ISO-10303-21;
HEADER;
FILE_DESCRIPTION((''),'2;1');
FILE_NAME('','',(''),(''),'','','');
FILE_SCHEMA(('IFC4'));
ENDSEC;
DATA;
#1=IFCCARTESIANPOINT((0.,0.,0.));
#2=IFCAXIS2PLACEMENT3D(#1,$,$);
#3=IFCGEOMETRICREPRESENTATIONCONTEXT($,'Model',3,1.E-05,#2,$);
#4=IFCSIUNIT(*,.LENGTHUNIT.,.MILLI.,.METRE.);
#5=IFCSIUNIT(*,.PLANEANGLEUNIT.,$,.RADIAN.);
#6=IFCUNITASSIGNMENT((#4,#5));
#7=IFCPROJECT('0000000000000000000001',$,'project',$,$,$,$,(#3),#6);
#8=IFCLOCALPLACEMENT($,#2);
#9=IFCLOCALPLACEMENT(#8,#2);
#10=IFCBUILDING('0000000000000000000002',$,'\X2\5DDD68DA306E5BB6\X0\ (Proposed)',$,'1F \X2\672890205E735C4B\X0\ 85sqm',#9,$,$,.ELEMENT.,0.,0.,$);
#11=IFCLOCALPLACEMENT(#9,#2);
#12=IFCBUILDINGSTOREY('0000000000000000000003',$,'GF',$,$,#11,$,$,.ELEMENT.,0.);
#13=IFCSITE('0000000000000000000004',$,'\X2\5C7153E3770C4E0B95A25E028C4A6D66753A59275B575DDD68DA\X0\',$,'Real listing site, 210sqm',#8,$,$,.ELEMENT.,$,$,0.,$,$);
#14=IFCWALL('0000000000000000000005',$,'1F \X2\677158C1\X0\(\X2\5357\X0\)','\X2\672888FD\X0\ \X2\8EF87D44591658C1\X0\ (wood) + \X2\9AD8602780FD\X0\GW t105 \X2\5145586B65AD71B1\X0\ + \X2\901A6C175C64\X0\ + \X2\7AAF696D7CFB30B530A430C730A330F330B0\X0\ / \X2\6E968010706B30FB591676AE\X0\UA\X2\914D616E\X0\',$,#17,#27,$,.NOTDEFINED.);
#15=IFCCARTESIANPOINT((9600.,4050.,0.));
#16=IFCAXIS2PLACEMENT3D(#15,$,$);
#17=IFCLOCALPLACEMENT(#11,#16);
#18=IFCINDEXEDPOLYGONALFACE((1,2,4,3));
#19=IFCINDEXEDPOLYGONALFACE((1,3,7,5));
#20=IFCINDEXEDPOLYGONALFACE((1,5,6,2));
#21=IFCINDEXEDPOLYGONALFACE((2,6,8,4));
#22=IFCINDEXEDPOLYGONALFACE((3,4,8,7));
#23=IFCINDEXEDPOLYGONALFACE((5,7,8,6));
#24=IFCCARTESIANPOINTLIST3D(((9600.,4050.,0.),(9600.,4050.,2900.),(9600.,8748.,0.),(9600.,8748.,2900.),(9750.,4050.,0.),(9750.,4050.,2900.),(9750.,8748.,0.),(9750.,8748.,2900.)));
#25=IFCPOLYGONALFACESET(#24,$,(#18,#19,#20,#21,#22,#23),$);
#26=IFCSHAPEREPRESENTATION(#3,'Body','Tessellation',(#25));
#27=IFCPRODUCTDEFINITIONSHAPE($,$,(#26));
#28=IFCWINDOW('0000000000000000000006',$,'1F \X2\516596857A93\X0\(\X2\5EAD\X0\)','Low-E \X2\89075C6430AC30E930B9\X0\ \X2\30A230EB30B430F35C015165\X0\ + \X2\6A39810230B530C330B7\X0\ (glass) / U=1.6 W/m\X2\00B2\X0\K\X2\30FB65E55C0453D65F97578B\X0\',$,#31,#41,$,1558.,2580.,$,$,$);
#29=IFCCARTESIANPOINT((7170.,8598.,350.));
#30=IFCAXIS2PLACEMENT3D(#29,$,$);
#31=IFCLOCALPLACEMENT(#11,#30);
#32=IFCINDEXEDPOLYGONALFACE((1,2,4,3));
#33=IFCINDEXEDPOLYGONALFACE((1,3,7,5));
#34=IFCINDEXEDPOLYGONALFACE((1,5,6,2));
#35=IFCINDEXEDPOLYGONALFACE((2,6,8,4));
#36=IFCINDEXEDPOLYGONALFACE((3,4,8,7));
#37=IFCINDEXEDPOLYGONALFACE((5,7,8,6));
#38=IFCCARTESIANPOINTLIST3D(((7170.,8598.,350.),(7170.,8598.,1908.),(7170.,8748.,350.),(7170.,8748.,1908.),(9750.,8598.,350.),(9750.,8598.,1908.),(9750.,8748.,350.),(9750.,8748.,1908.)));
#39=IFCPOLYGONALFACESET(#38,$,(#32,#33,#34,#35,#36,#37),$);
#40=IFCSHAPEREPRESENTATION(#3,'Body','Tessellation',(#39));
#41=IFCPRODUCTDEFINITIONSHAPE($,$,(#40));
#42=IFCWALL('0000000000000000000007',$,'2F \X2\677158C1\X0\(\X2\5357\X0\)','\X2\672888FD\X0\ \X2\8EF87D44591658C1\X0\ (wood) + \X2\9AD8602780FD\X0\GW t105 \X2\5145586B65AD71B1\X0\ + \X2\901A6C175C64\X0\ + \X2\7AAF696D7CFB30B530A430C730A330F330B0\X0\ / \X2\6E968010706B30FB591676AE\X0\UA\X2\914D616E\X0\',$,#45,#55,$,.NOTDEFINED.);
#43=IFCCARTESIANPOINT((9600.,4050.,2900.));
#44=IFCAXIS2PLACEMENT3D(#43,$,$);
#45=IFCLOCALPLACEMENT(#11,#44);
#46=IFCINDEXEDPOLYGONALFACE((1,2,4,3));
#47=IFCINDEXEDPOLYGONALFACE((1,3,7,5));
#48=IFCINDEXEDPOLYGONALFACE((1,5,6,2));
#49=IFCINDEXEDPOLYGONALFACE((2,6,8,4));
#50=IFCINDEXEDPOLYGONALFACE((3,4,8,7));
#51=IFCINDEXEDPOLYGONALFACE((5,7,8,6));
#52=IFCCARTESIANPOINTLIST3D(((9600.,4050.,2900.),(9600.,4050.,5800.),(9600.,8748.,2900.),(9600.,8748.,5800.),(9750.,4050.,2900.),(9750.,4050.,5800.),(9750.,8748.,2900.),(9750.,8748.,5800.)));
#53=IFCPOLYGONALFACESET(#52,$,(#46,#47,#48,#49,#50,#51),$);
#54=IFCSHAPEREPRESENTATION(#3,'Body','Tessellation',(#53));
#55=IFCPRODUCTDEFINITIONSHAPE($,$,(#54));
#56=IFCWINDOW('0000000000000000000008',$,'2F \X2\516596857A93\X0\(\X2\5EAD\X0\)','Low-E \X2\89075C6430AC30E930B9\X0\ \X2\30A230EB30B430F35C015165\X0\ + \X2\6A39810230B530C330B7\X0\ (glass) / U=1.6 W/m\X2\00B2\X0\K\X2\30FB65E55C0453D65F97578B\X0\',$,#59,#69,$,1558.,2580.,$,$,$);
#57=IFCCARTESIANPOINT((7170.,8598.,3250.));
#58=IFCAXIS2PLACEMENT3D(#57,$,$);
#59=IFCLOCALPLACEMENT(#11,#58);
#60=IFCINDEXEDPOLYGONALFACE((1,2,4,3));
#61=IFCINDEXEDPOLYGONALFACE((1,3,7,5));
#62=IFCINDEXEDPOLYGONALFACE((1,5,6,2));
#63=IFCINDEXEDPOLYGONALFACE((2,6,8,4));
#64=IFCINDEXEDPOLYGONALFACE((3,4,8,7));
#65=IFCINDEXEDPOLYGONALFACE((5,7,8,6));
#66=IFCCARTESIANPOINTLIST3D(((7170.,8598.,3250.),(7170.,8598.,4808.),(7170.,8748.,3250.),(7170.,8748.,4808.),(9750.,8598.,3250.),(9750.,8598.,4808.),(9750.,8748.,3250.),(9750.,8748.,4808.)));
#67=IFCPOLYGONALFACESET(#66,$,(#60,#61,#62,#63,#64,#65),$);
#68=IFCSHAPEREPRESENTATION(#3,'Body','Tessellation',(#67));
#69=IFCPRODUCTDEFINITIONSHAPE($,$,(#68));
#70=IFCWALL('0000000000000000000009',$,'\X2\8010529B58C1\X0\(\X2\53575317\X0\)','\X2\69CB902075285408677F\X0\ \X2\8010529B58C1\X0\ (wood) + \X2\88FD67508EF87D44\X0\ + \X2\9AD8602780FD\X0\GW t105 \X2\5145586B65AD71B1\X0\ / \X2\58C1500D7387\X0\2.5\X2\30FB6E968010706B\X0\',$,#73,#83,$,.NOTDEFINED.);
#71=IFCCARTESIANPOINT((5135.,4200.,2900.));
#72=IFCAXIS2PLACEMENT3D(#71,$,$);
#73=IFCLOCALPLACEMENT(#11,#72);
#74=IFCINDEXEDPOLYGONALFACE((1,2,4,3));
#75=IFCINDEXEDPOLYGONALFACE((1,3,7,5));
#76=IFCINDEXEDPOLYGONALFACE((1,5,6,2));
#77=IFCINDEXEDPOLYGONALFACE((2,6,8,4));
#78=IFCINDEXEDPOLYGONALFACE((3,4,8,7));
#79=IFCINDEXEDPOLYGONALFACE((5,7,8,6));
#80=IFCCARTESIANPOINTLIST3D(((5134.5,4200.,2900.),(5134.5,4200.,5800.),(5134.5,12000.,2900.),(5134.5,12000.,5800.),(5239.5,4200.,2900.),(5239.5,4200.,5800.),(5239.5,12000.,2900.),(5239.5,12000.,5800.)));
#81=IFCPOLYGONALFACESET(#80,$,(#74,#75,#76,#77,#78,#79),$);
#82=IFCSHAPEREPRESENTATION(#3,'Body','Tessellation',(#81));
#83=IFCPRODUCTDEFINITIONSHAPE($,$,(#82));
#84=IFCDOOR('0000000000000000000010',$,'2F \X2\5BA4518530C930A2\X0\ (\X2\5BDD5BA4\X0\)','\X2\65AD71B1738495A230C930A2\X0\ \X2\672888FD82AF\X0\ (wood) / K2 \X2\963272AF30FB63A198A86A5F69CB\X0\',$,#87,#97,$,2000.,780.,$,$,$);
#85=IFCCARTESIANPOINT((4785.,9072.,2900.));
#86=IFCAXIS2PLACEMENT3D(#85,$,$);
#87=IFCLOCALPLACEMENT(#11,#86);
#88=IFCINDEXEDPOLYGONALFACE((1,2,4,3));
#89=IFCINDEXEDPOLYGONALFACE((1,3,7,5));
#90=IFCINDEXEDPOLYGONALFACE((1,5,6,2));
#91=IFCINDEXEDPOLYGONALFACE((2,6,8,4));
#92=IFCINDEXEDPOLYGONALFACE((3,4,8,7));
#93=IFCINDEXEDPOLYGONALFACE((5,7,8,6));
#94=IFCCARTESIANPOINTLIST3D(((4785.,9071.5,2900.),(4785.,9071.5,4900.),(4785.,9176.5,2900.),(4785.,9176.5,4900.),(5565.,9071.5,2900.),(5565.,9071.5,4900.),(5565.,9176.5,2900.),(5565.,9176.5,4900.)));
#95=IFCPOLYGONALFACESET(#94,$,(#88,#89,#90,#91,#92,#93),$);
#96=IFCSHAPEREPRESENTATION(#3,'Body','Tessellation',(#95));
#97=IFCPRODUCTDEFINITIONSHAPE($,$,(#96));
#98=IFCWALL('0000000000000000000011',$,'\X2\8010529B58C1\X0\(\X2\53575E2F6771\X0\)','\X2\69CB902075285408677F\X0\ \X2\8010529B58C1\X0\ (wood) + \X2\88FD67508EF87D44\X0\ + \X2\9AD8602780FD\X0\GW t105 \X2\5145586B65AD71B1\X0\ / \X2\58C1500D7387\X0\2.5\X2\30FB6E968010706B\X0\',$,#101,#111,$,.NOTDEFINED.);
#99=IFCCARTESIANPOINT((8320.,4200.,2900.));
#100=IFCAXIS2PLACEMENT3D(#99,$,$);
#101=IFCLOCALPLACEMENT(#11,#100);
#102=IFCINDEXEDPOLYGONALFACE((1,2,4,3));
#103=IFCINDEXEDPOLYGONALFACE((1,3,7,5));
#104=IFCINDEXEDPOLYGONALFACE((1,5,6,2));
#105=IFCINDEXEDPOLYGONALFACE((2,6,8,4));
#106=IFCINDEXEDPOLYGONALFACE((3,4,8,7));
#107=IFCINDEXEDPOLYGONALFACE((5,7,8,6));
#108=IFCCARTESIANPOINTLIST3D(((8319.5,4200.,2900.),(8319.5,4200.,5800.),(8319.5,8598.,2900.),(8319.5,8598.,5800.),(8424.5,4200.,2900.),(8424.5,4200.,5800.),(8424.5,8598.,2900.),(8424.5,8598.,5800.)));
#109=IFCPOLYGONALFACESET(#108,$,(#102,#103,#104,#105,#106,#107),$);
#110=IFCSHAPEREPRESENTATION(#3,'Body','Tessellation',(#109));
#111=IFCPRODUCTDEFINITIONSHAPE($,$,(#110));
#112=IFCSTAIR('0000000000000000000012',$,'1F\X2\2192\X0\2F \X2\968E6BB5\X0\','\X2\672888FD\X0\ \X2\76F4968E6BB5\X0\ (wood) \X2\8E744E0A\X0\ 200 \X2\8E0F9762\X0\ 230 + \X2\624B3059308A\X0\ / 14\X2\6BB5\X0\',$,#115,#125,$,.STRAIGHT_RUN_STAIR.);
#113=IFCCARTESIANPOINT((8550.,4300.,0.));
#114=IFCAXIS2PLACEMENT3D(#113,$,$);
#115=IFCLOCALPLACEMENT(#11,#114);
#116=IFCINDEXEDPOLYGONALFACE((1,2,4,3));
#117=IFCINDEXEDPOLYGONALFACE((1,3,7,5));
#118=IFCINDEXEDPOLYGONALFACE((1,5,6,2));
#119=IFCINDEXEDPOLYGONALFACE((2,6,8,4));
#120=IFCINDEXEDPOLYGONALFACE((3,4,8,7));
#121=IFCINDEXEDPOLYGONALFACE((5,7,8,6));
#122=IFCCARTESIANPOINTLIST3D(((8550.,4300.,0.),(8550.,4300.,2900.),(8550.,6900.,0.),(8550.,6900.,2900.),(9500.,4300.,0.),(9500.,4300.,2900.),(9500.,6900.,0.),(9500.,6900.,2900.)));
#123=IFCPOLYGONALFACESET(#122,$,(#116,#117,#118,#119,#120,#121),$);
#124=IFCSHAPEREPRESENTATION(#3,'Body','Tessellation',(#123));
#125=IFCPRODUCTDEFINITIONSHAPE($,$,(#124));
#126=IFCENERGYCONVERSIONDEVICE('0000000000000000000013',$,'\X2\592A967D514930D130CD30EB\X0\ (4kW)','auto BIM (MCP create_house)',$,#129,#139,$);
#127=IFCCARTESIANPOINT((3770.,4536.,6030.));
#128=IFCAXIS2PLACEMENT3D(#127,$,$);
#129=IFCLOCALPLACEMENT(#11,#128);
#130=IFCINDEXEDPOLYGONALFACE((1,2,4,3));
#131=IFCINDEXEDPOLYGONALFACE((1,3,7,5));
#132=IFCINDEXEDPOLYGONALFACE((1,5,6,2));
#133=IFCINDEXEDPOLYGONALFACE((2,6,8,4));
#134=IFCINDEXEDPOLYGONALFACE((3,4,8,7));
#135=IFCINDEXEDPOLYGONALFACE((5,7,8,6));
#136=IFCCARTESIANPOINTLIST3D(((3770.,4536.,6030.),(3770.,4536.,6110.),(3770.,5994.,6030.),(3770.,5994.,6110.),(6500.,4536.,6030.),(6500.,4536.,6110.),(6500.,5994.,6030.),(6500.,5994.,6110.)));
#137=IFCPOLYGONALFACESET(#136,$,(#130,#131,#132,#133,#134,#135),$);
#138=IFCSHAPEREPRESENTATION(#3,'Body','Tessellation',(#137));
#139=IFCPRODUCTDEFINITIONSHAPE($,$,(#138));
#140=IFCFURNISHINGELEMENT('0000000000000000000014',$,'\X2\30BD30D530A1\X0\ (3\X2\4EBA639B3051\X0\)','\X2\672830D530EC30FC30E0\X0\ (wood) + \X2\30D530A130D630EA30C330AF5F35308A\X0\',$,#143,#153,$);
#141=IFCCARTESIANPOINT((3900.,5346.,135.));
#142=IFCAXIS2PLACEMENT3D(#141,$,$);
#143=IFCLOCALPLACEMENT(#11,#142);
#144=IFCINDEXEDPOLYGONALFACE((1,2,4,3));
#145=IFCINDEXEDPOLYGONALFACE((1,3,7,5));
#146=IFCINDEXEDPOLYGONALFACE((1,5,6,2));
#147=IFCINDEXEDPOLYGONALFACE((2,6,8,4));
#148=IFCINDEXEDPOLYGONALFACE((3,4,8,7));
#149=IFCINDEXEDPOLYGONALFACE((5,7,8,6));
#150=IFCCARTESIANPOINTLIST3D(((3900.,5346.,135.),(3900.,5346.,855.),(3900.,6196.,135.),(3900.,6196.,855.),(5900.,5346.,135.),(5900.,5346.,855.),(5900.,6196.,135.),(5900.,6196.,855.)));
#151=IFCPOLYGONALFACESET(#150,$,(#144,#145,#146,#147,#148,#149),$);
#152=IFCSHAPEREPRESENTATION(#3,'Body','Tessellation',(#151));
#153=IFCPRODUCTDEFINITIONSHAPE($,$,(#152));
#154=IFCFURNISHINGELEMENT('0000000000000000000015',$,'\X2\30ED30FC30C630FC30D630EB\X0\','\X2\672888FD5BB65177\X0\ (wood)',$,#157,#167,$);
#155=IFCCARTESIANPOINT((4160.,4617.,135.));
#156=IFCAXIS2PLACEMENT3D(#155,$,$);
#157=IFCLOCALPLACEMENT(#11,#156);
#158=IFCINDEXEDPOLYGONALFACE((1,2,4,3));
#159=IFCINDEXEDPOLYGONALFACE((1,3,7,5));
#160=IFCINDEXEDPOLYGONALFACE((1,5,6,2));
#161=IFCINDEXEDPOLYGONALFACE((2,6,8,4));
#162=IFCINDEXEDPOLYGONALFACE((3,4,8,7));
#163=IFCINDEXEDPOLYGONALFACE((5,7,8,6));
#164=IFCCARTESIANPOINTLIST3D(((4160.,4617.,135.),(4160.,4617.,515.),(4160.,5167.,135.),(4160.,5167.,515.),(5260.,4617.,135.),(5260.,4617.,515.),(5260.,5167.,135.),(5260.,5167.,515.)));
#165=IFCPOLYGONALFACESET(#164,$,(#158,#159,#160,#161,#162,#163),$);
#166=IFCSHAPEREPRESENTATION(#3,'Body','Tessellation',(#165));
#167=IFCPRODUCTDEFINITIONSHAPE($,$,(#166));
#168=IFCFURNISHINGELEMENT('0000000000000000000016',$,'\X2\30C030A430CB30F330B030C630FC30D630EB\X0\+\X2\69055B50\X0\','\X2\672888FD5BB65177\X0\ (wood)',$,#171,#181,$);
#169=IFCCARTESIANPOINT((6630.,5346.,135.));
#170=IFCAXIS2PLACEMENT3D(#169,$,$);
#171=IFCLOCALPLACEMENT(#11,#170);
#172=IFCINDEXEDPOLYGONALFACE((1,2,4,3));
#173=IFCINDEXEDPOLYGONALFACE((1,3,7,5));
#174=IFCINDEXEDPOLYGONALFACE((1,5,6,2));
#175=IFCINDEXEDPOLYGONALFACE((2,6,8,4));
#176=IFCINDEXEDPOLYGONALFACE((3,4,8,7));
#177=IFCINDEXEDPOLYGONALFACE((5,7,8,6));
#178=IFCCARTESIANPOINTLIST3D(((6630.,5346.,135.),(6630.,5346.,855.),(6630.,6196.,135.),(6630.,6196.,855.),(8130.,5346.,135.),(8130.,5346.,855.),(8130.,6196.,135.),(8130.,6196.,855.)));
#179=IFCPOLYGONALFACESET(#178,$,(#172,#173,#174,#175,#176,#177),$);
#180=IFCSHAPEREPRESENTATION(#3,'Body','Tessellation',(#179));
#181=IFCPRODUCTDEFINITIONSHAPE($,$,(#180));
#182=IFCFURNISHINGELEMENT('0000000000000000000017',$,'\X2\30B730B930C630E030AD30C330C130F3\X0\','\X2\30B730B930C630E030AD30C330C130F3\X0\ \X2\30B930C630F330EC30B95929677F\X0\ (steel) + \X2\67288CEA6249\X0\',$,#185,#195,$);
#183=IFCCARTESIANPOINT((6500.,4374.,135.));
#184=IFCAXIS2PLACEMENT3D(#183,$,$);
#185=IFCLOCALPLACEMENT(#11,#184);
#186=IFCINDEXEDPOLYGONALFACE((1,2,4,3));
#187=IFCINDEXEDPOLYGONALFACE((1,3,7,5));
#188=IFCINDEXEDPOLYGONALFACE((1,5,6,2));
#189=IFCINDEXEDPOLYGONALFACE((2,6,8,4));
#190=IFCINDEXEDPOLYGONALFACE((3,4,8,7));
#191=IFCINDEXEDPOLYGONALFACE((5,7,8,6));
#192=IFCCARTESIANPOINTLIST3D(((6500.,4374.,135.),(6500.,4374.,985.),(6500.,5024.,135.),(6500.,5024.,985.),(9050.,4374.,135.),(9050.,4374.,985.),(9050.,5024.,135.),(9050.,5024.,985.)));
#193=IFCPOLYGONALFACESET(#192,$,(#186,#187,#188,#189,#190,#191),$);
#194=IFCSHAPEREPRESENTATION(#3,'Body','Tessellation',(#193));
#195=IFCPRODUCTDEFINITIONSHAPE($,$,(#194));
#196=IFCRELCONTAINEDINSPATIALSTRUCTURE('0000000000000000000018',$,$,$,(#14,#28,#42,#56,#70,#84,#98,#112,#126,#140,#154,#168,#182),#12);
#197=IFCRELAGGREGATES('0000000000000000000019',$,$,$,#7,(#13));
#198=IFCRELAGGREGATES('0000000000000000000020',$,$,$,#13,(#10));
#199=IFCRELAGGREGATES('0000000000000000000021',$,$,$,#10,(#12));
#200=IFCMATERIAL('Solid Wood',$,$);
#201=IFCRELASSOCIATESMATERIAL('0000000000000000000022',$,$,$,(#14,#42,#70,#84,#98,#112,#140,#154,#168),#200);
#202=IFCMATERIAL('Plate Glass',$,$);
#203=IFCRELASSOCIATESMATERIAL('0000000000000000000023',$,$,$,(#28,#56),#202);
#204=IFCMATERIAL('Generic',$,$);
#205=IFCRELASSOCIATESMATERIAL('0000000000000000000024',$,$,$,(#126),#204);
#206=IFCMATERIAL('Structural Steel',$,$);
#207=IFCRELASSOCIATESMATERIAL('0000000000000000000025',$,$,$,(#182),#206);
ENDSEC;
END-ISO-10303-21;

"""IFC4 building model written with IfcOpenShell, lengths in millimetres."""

from ifc_helpers import new_model, si_unit, frame, frame_2d, origin, place, context, project, spatial, rectangle, extrude, material, element, fill, save


model = new_model("IFC4")

# Units and contexts
model_context = context("Model", 3, precision=1e-05, world=origin())
ifc_project = project(units=[si_unit("LENGTHUNIT", "METRE", prefix="MILLI"), si_unit("PLANEANGLEUNIT", "RADIAN")], contexts=[model_context])

# Site, building, storey
site_placement = place(None, origin())
site = spatial("IfcSite", under=ifc_project, at=site_placement, Name="山口県下関市豊浦町大字川棚", ObjectType="Real listing site, 210sqm", CompositionType="ELEMENT", RefElevation=0.0)
building_placement = place(site_placement, origin())
building = spatial("IfcBuilding", under=site, at=building_placement, Name="川棚の家 (Proposed)", ObjectType="1F 木造平屋 85sqm", CompositionType="ELEMENT", ElevationOfRefHeight=0.0, ElevationOfTerrain=0.0)
storey_placement = place(building_placement, origin())
storey = spatial("IfcBuildingStorey", under=building, at=storey_placement, Name="GF", CompositionType="ELEMENT", Elevation=0.0)

# Wall, opening, window
ifc_material_1 = material(Name="Solid Wood")
wall_1_placement = place(storey_placement, frame((9600.0, 4050.0, 0.0)))
wall_1 = element("IfcWall", 1, at=wall_1_placement, inside=storey, material=ifc_material_1, Name="1F 東壁(南)", Description="木製 軸組外壁 (wood) + 高性能GW t105 充填断熱 + 通気層 + 窯業系サイディング / 準耐火・外皮UA配慮", PredefinedType="NOTDEFINED", context=model_context, shape_type="SweptSolid", body=[
    extrude(rectangle(XDim=150.0, YDim=4698.0, at=frame_2d((75.0, 2349.0))), frame((9600.0, 4050.0, 0.0)), (0.0, 0.0, 1.0), 2900.0),
])
opening_1_placement = place(storey_placement, frame((7170.0, 8598.0, 350.0)))
opening_1 = element("IfcOpeningElement", 2, at=opening_1_placement, cuts=wall_1, PredefinedType="NOTDEFINED", context=model_context, shape_type="SweptSolid", body=[
    extrude(rectangle(XDim=2580.0, YDim=150.0, at=frame_2d((1290.0, 75.0))), frame((7170.0, 8598.0, 350.0)), (0.0, 0.0, 1.0), 1558.0),
])
ifc_material_2 = material(Name="Plate Glass")
window_1_placement = place(storey_placement, frame((7170.0, 8598.0, 350.0)))
window_1 = element("IfcWindow", 3, at=window_1_placement, inside=storey, material=ifc_material_2, Name="1F 入隅窓(庭)", Description="Low-E 複層ガラス アルゴン封入 + 樹脂サッシ (glass) / U=1.6 W/m²K・日射取得型", OverallHeight=1558.0, OverallWidth=2580.0, context=model_context, shape_type="SweptSolid", body=[
    extrude(rectangle(XDim=2580.0, YDim=150.0, at=frame_2d((1290.0, 75.0))), frame((7170.0, 8598.0, 350.0)), (0.0, 0.0, 1.0), 1558.0),
])
fill(opening_1, window_1)

# Wall, opening, window
wall_2_placement = place(storey_placement, frame((9600.0, 4050.0, 2900.0)))
wall_2 = element("IfcWall", 4, at=wall_2_placement, inside=storey, material=ifc_material_1, Name="2F 東壁(南)", Description="木製 軸組外壁 (wood) + 高性能GW t105 充填断熱 + 通気層 + 窯業系サイディング / 準耐火・外皮UA配慮", PredefinedType="NOTDEFINED", context=model_context, shape_type="SweptSolid", body=[
    extrude(rectangle(XDim=150.0, YDim=4698.0, at=frame_2d((75.0, 2349.0))), frame((9600.0, 4050.0, 2900.0)), (0.0, 0.0, 1.0), 2900.0),
])
opening_2_placement = place(storey_placement, frame((7170.0, 8598.0, 3250.0)))
opening_2 = element("IfcOpeningElement", 5, at=opening_2_placement, cuts=wall_2, PredefinedType="NOTDEFINED", context=model_context, shape_type="SweptSolid", body=[
    extrude(rectangle(XDim=2580.0, YDim=150.0, at=frame_2d((1290.0, 75.0))), frame((7170.0, 8598.0, 3250.0)), (0.0, 0.0, 1.0), 1558.0),
])
window_2_placement = place(storey_placement, frame((7170.0, 8598.0, 3250.0)))
window_2 = element("IfcWindow", 6, at=window_2_placement, inside=storey, material=ifc_material_2, Name="2F 入隅窓(庭)", Description="Low-E 複層ガラス アルゴン封入 + 樹脂サッシ (glass) / U=1.6 W/m²K・日射取得型", OverallHeight=1558.0, OverallWidth=2580.0, context=model_context, shape_type="SweptSolid", body=[
    extrude(rectangle(XDim=2580.0, YDim=150.0, at=frame_2d((1290.0, 75.0))), frame((7170.0, 8598.0, 3250.0)), (0.0, 0.0, 1.0), 1558.0),
])
fill(opening_2, window_2)

# Wall, opening, door
wall_3_placement = place(storey_placement, frame((5135.0, 4200.0, 2900.0)))
wall_3 = element("IfcWall", 7, at=wall_3_placement, inside=storey, material=ifc_material_1, Name="耐力壁(南北)", Description="構造用合板 耐力壁 (wood) + 製材軸組 + 高性能GW t105 充填断熱 / 壁倍率2.5・準耐火", PredefinedType="NOTDEFINED", context=model_context, shape_type="SweptSolid", body=[
    extrude(rectangle(XDim=105.0, YDim=7800.0, at=frame_2d((52.0, 3900.0))), frame((5135.0, 4200.0, 2900.0)), (0.0, 0.0, 1.0), 2900.0),
])
opening_3_placement = place(storey_placement, frame((4785.0, 9072.0, 2900.0)))
opening_3 = element("IfcOpeningElement", 8, at=opening_3_placement, cuts=wall_3, PredefinedType="NOTDEFINED", context=model_context, shape_type="SweptSolid", body=[
    extrude(rectangle(XDim=780.0, YDim=105.0, at=frame_2d((390.0, 52.0))), frame((4785.0, 9072.0, 2900.0)), (0.0, 0.0, 1.0), 2000.0),
])
door_1_placement = place(storey_placement, frame((4785.0, 9072.0, 2900.0)))
door_1 = element("IfcDoor", 9, at=door_1_placement, inside=storey, material=ifc_material_1, Name="2F 室内ドア (寝室)", Description="断熱玄関ドア 木製芯 (wood) / K2 防犯・採風機構", OverallHeight=2000.0, OverallWidth=780.0, context=model_context, shape_type="SweptSolid", body=[
    extrude(rectangle(XDim=780.0, YDim=105.0, at=frame_2d((390.0, 52.0))), frame((4785.0, 9072.0, 2900.0)), (0.0, 0.0, 1.0), 2000.0),
])
fill(opening_3, door_1)

# Wall
wall_4_placement = place(storey_placement, frame((8320.0, 4200.0, 2900.0)))
element("IfcWall", 10, at=wall_4_placement, inside=storey, material=ifc_material_1, Name="耐力壁(南帯東)", Description="構造用合板 耐力壁 (wood) + 製材軸組 + 高性能GW t105 充填断熱 / 壁倍率2.5・準耐火", PredefinedType="NOTDEFINED", context=model_context, shape_type="SweptSolid", body=[
    extrude(rectangle(XDim=105.0, YDim=4398.0, at=frame_2d((52.0, 2199.0))), frame((8320.0, 4200.0, 2900.0)), (0.0, 0.0, 1.0), 2900.0),
])

# Stair
stair_placement = place(storey_placement, frame((8550.0, 4300.0, 0.0)))
element("IfcStair", 11, at=stair_placement, inside=storey, material=ifc_material_1, Name="1F→2F 階段", Description="木製 直階段 (wood) 蹴上 200 踏面 230 + 手すり / 14段", PredefinedType="STRAIGHT_RUN_STAIR", context=model_context, shape_type="SweptSolid", body=[
    extrude(rectangle(XDim=950.0, YDim=2600.0, at=frame_2d((475.0, 1300.0))), frame((8550.0, 4300.0, 0.0)), (0.0, 0.0, 1.0), 2900.0),
])

# Energy conversion device
ifc_material_3 = material(Name="Generic")
energy_conversion_device_placement = place(storey_placement, frame((3770.0, 4536.0, 6030.0)))
element("IfcEnergyConversionDevice", 12, at=energy_conversion_device_placement, inside=storey, material=ifc_material_3, Name="太陽光パネル (4kW)", Description="auto BIM (MCP create_house)", context=model_context, shape_type="SweptSolid", body=[
    extrude(rectangle(XDim=2730.0, YDim=1458.0, at=frame_2d((1365.0, 729.0))), frame((3770.0, 4536.0, 6030.0)), (0.0, 0.0, 1.0), 80.0),
])

# Furnishing elements
furnishing_1_placement = place(storey_placement, frame((3900.0, 5346.0, 135.0)))
element("IfcFurnishingElement", 13, at=furnishing_1_placement, inside=storey, material=ifc_material_1, Name="ソファ (3人掛け)", Description="木フレーム (wood) + ファブリック張り", context=model_context, shape_type="SweptSolid", body=[
    extrude(rectangle(XDim=2000.0, YDim=850.0, at=frame_2d((1000.0, 425.0))), frame((3900.0, 5346.0, 135.0)), (0.0, 0.0, 1.0), 720.0),
])
furnishing_2_placement = place(storey_placement, frame((4160.0, 4617.0, 135.0)))
element("IfcFurnishingElement", 14, at=furnishing_2_placement, inside=storey, material=ifc_material_1, Name="ローテーブル", Description="木製家具 (wood)", context=model_context, shape_type="SweptSolid", body=[
    extrude(rectangle(XDim=1100.0, YDim=550.0, at=frame_2d((550.0, 275.0))), frame((4160.0, 4617.0, 135.0)), (0.0, 0.0, 1.0), 380.0),
])
furnishing_3_placement = place(storey_placement, frame((6630.0, 5346.0, 135.0)))
element("IfcFurnishingElement", 15, at=furnishing_3_placement, inside=storey, material=ifc_material_1, Name="ダイニングテーブル+椅子", Description="木製家具 (wood)", context=model_context, shape_type="SweptSolid", body=[
    extrude(rectangle(XDim=1500.0, YDim=850.0, at=frame_2d((750.0, 425.0))), frame((6630.0, 5346.0, 135.0)), (0.0, 0.0, 1.0), 720.0),
])
ifc_material_4 = material(Name="Structural Steel")
furnishing_4_placement = place(storey_placement, frame((6500.0, 4374.0, 135.0)))
element("IfcFurnishingElement", 16, at=furnishing_4_placement, inside=storey, material=ifc_material_4, Name="システムキッチン", Description="システムキッチン ステンレス天板 (steel) + 木質扉", context=model_context, shape_type="SweptSolid", body=[
    extrude(rectangle(XDim=2550.0, YDim=650.0, at=frame_2d((1275.0, 325.0))), frame((6500.0, 4374.0, 135.0)), (0.0, 0.0, 1.0), 850.0),
])

save(model, "model.ifc")
